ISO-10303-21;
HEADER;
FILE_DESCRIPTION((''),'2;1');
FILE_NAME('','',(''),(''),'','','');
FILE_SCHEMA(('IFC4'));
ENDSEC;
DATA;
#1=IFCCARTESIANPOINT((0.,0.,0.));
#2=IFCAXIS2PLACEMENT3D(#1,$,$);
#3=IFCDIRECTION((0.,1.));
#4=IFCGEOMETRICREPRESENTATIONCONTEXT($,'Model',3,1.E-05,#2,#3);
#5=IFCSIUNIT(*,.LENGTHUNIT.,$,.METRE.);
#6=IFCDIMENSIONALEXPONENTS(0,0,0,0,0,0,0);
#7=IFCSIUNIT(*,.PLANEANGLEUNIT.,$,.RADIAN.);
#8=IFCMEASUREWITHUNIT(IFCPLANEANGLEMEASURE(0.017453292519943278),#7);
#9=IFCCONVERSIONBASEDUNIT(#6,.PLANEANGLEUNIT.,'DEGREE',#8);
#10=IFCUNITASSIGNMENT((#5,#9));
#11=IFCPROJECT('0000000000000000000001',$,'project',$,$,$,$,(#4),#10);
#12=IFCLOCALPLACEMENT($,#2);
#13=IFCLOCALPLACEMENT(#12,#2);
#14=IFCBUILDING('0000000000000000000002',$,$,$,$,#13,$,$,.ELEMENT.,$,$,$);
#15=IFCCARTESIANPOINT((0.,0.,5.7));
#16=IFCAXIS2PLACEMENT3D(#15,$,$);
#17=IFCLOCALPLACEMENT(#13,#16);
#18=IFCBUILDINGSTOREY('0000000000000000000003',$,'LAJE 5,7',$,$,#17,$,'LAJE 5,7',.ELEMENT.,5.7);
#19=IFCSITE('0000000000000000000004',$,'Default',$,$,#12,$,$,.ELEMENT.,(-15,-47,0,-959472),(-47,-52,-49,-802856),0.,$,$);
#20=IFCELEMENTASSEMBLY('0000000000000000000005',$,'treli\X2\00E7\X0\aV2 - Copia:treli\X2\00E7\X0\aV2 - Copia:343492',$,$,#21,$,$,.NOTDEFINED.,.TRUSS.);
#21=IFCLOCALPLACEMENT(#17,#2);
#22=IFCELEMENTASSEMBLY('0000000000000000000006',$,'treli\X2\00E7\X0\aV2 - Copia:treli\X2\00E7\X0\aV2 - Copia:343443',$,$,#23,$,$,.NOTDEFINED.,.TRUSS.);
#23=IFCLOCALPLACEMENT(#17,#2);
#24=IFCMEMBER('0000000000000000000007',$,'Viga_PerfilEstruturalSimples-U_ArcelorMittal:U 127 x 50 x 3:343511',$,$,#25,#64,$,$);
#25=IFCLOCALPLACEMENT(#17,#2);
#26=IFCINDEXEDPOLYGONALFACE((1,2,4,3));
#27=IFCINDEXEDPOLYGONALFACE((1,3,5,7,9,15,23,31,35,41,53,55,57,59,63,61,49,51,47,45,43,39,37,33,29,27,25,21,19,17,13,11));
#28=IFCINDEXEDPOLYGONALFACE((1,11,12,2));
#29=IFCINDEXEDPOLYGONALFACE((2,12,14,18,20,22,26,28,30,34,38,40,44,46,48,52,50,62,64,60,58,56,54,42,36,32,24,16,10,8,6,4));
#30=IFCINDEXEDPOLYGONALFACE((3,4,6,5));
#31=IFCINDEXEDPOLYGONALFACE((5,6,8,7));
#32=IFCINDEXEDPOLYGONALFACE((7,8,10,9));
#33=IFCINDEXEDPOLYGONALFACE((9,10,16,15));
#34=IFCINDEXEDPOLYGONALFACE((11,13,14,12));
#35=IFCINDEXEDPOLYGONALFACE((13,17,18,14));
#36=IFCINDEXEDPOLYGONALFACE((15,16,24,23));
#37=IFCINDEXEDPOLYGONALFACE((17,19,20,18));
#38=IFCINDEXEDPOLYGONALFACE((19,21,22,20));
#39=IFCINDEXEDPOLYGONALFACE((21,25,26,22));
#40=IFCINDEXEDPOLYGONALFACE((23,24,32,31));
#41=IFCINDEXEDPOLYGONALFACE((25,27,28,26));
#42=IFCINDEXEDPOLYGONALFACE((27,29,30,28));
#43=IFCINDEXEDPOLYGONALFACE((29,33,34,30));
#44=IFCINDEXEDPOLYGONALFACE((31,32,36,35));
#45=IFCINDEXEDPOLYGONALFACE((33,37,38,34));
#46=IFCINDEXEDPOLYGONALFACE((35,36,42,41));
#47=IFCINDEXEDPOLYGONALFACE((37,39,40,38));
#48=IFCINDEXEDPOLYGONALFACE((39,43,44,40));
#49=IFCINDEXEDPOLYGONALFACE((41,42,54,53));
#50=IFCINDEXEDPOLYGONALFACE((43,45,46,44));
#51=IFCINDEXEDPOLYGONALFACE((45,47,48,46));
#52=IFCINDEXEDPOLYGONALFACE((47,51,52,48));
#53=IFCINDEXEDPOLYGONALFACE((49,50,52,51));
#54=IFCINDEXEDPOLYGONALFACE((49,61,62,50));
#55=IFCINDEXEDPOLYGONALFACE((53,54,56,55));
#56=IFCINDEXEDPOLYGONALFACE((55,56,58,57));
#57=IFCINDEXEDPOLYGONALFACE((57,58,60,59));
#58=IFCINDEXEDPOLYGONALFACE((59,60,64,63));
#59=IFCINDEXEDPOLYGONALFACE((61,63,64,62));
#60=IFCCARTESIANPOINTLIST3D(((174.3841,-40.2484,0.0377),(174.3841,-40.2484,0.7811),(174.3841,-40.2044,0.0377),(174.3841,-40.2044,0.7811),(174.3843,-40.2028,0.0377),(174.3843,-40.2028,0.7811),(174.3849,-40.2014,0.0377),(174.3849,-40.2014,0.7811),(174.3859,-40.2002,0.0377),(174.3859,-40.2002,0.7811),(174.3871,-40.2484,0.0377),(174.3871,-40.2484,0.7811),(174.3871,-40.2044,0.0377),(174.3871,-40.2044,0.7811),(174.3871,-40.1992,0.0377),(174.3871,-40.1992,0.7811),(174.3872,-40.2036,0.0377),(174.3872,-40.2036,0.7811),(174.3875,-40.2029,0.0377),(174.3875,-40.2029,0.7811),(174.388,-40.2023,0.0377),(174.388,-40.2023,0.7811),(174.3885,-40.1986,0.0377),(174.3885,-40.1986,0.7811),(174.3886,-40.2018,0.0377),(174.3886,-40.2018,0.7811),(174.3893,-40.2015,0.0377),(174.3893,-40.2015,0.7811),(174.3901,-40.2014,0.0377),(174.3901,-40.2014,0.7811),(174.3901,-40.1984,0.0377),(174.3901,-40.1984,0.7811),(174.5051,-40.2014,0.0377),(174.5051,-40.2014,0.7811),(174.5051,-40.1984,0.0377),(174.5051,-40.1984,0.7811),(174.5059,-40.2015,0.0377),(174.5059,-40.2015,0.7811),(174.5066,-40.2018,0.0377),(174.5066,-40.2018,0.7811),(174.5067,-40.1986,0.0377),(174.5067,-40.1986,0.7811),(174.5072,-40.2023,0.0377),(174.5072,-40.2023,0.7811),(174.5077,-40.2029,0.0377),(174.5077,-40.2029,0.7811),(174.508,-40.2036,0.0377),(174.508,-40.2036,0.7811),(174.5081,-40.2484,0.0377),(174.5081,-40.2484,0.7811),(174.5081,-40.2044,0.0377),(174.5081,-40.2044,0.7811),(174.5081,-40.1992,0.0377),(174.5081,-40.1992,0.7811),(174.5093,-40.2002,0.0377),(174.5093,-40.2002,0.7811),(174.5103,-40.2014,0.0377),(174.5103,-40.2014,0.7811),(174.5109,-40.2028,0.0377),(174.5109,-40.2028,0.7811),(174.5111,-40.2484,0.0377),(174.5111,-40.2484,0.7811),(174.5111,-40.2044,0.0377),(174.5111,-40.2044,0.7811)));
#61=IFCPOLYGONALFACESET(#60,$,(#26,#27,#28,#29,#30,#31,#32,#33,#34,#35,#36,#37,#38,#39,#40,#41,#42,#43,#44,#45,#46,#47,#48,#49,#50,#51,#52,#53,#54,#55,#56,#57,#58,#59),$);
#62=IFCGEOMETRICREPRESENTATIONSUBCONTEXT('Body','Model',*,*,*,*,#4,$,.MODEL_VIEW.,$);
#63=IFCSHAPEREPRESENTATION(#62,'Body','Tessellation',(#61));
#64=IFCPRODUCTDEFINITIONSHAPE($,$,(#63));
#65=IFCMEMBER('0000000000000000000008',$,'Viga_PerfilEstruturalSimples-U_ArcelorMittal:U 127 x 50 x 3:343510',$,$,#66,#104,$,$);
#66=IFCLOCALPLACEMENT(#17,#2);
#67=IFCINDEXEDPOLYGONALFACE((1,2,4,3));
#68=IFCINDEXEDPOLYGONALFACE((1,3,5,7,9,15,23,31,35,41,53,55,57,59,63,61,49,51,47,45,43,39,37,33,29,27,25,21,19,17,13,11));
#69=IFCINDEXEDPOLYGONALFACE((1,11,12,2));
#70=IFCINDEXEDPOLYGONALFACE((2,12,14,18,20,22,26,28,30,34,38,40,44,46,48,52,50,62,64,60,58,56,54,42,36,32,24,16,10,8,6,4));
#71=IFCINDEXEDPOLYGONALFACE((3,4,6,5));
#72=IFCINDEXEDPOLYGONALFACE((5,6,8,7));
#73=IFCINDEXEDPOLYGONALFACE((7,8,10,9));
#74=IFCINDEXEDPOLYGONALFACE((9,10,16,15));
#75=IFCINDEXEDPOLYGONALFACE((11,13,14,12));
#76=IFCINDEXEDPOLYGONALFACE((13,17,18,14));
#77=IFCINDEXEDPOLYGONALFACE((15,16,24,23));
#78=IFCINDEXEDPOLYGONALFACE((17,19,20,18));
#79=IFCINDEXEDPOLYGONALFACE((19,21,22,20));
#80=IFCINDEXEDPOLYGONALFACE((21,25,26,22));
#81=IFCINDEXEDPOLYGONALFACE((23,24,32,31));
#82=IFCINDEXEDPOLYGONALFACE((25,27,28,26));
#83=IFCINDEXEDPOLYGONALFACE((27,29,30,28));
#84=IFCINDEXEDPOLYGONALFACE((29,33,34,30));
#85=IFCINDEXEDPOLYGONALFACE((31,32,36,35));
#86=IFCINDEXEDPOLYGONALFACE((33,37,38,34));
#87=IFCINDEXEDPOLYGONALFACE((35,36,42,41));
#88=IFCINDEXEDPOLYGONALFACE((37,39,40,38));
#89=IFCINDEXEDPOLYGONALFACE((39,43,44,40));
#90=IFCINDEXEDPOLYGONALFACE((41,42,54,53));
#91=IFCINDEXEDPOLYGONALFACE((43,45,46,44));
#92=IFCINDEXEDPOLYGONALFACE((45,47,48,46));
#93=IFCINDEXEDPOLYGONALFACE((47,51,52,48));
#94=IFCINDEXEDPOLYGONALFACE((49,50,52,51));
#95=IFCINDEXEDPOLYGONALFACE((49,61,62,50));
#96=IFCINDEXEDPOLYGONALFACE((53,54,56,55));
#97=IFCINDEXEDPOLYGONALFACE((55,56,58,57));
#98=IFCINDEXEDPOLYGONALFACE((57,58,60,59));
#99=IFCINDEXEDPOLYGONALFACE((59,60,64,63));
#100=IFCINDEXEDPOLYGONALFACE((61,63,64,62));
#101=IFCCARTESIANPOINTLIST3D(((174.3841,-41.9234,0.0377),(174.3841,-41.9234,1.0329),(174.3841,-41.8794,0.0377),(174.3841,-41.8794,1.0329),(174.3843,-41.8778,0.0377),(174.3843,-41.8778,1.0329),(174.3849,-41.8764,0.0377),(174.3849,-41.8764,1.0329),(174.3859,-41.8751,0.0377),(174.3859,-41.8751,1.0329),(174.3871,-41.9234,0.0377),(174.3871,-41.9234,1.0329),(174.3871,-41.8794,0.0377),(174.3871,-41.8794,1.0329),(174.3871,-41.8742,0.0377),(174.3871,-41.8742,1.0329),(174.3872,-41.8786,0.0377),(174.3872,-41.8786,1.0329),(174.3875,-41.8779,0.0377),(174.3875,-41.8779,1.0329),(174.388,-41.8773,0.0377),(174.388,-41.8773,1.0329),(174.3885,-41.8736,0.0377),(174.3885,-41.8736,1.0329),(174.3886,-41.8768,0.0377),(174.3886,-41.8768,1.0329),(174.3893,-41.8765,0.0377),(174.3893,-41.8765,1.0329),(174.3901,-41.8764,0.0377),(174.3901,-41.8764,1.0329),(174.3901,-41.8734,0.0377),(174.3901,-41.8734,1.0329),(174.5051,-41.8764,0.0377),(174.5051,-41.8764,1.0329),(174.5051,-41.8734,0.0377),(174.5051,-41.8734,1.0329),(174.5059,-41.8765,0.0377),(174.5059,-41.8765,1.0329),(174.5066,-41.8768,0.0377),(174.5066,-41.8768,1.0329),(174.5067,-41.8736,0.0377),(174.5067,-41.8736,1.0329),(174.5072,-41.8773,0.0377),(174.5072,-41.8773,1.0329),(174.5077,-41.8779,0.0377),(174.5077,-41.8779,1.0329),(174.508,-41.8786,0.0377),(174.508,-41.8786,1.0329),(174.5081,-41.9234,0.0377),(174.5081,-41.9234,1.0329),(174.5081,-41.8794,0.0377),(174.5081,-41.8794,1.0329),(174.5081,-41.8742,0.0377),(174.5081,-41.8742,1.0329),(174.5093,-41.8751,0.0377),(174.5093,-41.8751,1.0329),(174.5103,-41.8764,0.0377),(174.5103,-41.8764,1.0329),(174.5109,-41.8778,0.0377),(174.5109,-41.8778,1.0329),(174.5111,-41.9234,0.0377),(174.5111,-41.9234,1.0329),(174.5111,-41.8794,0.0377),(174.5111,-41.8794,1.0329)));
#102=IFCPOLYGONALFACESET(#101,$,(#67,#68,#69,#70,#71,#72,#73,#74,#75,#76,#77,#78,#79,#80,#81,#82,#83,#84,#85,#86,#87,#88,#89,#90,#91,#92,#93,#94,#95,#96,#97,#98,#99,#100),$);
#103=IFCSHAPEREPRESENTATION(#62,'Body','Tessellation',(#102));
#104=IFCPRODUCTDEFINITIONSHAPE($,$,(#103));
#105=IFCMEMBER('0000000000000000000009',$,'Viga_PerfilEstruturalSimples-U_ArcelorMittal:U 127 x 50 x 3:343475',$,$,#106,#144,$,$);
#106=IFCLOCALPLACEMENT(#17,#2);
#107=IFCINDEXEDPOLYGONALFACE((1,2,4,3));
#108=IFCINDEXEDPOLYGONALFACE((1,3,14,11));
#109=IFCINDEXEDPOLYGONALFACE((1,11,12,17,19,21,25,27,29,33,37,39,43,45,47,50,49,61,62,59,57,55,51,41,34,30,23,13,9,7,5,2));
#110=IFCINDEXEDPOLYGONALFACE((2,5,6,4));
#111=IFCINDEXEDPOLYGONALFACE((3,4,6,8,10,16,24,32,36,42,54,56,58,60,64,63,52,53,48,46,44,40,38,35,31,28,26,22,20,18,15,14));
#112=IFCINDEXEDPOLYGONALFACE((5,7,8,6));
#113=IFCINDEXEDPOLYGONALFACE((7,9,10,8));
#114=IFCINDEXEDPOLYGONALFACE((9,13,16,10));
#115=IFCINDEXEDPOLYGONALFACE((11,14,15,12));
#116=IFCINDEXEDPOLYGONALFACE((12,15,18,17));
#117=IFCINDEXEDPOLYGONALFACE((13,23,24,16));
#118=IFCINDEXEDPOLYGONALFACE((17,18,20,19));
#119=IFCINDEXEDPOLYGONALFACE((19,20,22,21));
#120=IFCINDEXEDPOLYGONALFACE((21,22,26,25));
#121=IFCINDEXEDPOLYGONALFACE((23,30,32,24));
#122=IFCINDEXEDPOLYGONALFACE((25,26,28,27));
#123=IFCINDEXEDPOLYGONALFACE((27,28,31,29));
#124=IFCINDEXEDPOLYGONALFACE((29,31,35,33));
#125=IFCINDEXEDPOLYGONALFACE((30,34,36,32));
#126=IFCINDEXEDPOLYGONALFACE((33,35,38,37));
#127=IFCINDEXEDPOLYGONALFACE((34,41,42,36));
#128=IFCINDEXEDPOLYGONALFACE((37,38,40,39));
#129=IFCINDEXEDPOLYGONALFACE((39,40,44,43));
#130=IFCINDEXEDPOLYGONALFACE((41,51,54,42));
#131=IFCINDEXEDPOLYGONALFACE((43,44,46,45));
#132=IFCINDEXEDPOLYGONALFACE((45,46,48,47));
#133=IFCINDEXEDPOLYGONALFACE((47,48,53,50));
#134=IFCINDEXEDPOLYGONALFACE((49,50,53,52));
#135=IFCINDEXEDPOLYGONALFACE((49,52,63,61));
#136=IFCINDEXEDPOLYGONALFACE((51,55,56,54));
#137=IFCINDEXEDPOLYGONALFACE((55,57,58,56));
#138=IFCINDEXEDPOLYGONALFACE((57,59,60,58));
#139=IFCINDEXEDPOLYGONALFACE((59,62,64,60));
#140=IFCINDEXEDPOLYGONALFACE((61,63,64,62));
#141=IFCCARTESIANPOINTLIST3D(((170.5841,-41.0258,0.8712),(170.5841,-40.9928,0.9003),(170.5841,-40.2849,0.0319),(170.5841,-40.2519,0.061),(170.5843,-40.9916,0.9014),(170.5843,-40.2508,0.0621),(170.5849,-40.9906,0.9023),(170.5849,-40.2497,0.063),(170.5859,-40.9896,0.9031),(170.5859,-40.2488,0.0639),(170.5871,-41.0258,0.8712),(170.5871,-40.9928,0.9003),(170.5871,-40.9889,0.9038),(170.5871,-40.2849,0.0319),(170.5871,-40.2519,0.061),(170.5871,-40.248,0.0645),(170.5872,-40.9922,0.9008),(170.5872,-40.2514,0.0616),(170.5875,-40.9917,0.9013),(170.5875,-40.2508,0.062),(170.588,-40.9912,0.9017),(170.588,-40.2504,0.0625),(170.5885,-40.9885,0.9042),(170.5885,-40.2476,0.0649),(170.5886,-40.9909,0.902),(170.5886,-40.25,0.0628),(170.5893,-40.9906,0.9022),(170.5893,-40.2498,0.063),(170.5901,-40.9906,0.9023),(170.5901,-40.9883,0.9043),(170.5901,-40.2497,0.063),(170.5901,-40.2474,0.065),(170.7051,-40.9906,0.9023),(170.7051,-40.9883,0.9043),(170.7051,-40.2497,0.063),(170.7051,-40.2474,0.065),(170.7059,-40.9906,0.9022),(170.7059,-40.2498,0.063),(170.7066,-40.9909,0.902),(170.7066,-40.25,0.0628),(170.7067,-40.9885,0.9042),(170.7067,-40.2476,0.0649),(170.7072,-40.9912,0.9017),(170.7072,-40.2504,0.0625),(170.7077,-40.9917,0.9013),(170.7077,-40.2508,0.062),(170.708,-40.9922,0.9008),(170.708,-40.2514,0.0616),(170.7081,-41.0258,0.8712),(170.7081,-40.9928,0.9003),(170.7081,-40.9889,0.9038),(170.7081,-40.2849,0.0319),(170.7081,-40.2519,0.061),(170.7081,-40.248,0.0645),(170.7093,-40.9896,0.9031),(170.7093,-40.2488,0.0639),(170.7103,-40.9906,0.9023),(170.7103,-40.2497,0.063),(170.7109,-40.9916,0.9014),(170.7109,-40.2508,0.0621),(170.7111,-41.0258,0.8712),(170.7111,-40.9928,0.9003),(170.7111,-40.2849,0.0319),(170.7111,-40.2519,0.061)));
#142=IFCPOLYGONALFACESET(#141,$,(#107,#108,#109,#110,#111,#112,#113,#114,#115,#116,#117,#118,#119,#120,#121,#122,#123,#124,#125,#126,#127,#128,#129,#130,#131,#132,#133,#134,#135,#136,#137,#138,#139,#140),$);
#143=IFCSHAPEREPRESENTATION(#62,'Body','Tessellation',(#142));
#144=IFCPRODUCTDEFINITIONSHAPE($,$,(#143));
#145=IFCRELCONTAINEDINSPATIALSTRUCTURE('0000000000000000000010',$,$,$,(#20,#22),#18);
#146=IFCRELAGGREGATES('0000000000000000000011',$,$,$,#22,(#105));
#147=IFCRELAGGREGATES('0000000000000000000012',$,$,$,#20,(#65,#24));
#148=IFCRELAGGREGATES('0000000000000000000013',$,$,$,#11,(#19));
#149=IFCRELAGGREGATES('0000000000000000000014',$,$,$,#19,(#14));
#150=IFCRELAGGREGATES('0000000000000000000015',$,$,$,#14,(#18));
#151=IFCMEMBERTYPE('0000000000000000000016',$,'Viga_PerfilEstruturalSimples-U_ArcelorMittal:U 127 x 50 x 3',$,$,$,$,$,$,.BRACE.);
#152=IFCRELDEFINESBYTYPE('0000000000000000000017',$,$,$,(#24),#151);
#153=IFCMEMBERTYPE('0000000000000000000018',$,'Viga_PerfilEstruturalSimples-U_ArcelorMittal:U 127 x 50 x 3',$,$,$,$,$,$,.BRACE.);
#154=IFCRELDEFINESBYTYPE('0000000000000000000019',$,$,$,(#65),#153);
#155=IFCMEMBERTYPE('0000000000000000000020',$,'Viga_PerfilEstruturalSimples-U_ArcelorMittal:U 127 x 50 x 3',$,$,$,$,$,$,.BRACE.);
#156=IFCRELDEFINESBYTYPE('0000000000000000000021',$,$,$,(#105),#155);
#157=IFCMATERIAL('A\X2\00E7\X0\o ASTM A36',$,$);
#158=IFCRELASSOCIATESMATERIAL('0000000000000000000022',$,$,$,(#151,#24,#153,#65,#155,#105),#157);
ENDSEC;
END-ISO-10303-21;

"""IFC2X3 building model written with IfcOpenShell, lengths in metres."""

from ifc_helpers import new_model, entity, si_unit, converted_unit, direction, frame, frame_2d, origin, place, context, subcontext, project, spatial, polyline, circle_curve, parameter, trimmed, segment, composite_curve, outline, extrude, source, transform, mapped, material, type_object, type_shapes, element, aggregate, save


model = new_model("IFC2X3")

# Units and contexts
model_context = context("Model", 3, precision=1e-05, world=origin(), true_north=direction((0.0, 1.0)))
body_context = subcontext(model_context, "Body", "Model", "MODEL_VIEW")
ifc_project = project(units=[si_unit("LENGTHUNIT", "METRE"), converted_unit("PLANEANGLEUNIT", "DEGREE", entity("IfcPlaneAngleMeasure", 0.017453292519943278), si_unit("PLANEANGLEUNIT", "RADIAN"), dimensions=[0, 0, 0, 0, 0, 0, 0])], contexts=[model_context])

# Site, building, storey
site_placement = place(None, origin())
site = spatial("IfcSite", under=ifc_project, at=site_placement, Name="Default", CompositionType="ELEMENT", RefLatitude=(-15, -47, 0, -959472), RefLongitude=(-47, -52, -49, -802856), RefElevation=0.0)
building_placement = place(site_placement, origin())
building = spatial("IfcBuilding", under=site, at=building_placement, CompositionType="ELEMENT")
storey_placement = place(building_placement, frame((0.0, 0.0, 5.7)))
storey = spatial("IfcBuildingStorey", under=building, at=storey_placement, Name="LAJE 5,7", LongName="LAJE 5,7", CompositionType="ELEMENT", Elevation=5.7)

# Element assembly
assembly_1_placement = place(storey_placement, origin())
assembly_1 = element("IfcElementAssembly", 1, at=assembly_1_placement, inside=storey, Name="treliçaV2 - Copia:treliçaV2 - Copia:343492", AssemblyPlace="NOTDEFINED", PredefinedType="TRUSS")
ifc_material = material(Name="Aço ASTM A36")

# Element assembly
assembly_2_placement = place(storey_placement, origin())
assembly_2 = element("IfcElementAssembly", 2, at=assembly_2_placement, inside=storey, Name="treliçaV2 - Copia:treliçaV2 - Copia:343443", AssemblyPlace="NOTDEFINED", PredefinedType="TRUSS")

# Members
member_type_1 = type_object("IfcMemberType", Name="Viga_PerfilEstruturalSimples-U_ArcelorMittal:U 127 x 50 x 3", PredefinedType="BRACE", material=ifc_material)
shared_shape_1 = source(origin(), body_context, "Body", "SweptSolid", [
    extrude(outline(composite_curve([segment(polyline([(-0.0575, -0.0192), (0.0575, -0.0192)]), True, "CONTINUOUS"), segment(trimmed(circle_curve(frame_2d((0.0575, -0.0132), x_axis=(0.0, 1.0)), 0.006), [parameter(180.0)], [parameter(270.0)], True, "PARAMETER"), True, "CONTINUOUS"), segment(polyline([(0.0635, -0.0132), (0.0635, 0.0308)]), True, "CONTINUOUS"), segment(polyline([(0.0635, 0.0308), (0.0605, 0.0308)]), True, "CONTINUOUS"), segment(polyline([(0.0605, 0.0308), (0.0605, -0.0132)]), True, "CONTINUOUS"), segment(trimmed(circle_curve(frame_2d((0.0575, -0.0132), x_axis=(0.0, 1.0)), 0.003), [parameter(180.0)], [parameter(270.0)], True, "PARAMETER"), False, "CONTINUOUS"), segment(polyline([(0.0575, -0.0162), (-0.0575, -0.0162)]), True, "CONTINUOUS"), segment(trimmed(circle_curve(frame_2d((-0.0575, -0.0132), x_axis=(0.0, 1.0)), 0.003), [parameter(90.0)], [parameter(180.0)], True, "PARAMETER"), False, "CONTINUOUS"), segment(polyline([(-0.0605, -0.0132), (-0.0605, 0.0308)]), True, "CONTINUOUS"), segment(polyline([(-0.0605, 0.0308), (-0.0635, 0.0308)]), True, "CONTINUOUS"), segment(polyline([(-0.0635, 0.0308), (-0.0635, -0.0132)]), True, "CONTINUOUS"), segment(trimmed(circle_curve(frame_2d((-0.0575, -0.0132), x_axis=(0.0, 1.0)), 0.006), [parameter(90.0)], [parameter(180.0)], True, "PARAMETER"), True, "CONTINUOUS")], self_intersect=False)), frame((-0.3737, -0.0058, 0.0), z_axis=(1.0, 0.0, 0.0), x_axis=(0.0, 0.0, -1.0)), (0.0, 0.0, 1.0), 0.7434),
])
type_shapes(member_type_1, [shared_shape_1])
member_1_placement = place(assembly_1_placement, frame((174.4476, -40.2234, 0.4114), z_axis=(1.0, 0.0, 0.0), x_axis=(0.0, 0.0, 1.0)))
member_1 = element("IfcMember", 3, at=member_1_placement, type_object=member_type_1, material=ifc_material, Name="Viga_PerfilEstruturalSimples-U_ArcelorMittal:U 127 x 50 x 3:343511", context=body_context, shape_type="MappedRepresentation", body=[
    mapped(shared_shape_1, transform((0.0, 0.0, 0.0), scale=1.0)),
])
member_type_2 = type_object("IfcMemberType", Name="Viga_PerfilEstruturalSimples-U_ArcelorMittal:U 127 x 50 x 3", PredefinedType="BRACE", material=ifc_material)
shared_shape_2 = source(origin(), body_context, "Body", "SweptSolid", [
    extrude(outline(composite_curve([segment(polyline([(-0.0575, -0.0192), (0.0575, -0.0192)]), True, "CONTINUOUS"), segment(trimmed(circle_curve(frame_2d((0.0575, -0.0132), x_axis=(0.0, 1.0)), 0.006), [parameter(180.0)], [parameter(270.0)], True, "PARAMETER"), True, "CONTINUOUS"), segment(polyline([(0.0635, -0.0132), (0.0635, 0.0308)]), True, "CONTINUOUS"), segment(polyline([(0.0635, 0.0308), (0.0605, 0.0308)]), True, "CONTINUOUS"), segment(polyline([(0.0605, 0.0308), (0.0605, -0.0132)]), True, "CONTINUOUS"), segment(trimmed(circle_curve(frame_2d((0.0575, -0.0132), x_axis=(0.0, 1.0)), 0.003), [parameter(180.0)], [parameter(270.0)], True, "PARAMETER"), False, "CONTINUOUS"), segment(polyline([(0.0575, -0.0162), (-0.0575, -0.0162)]), True, "CONTINUOUS"), segment(trimmed(circle_curve(frame_2d((-0.0575, -0.0132), x_axis=(0.0, 1.0)), 0.003), [parameter(90.0)], [parameter(180.0)], True, "PARAMETER"), False, "CONTINUOUS"), segment(polyline([(-0.0605, -0.0132), (-0.0605, 0.0308)]), True, "CONTINUOUS"), segment(polyline([(-0.0605, 0.0308), (-0.0635, 0.0308)]), True, "CONTINUOUS"), segment(polyline([(-0.0635, 0.0308), (-0.0635, -0.0132)]), True, "CONTINUOUS"), segment(trimmed(circle_curve(frame_2d((-0.0575, -0.0132), x_axis=(0.0, 1.0)), 0.006), [parameter(90.0)], [parameter(180.0)], True, "PARAMETER"), True, "CONTINUOUS")], self_intersect=False)), frame((-0.4996, -0.0058, 0.0), z_axis=(1.0, 0.0, 0.0), x_axis=(0.0, 0.0, -1.0)), (0.0, 0.0, 1.0), 0.9952),
])
type_shapes(member_type_2, [shared_shape_2])
member_2_placement = place(assembly_1_placement, frame((174.4476, -41.8984, 0.5373), z_axis=(1.0, 0.0, 0.0), x_axis=(0.0, 0.0, 1.0)))
member_2 = element("IfcMember", 4, at=member_2_placement, type_object=member_type_2, material=ifc_material, Name="Viga_PerfilEstruturalSimples-U_ArcelorMittal:U 127 x 50 x 3:343510", context=body_context, shape_type="MappedRepresentation", body=[
    mapped(shared_shape_2, transform((0.0, 0.0, 0.0), scale=1.0)),
])
member_type_3 = type_object("IfcMemberType", Name="Viga_PerfilEstruturalSimples-U_ArcelorMittal:U 127 x 50 x 3", PredefinedType="BRACE", material=ifc_material)
shared_shape_3 = source(origin(), body_context, "Body", "SweptSolid", [
    extrude(outline(composite_curve([segment(polyline([(-0.0575, -0.0192), (0.0575, -0.0192)]), True, "CONTINUOUS"), segment(trimmed(circle_curve(frame_2d((0.0575, -0.0132), x_axis=(0.0, 1.0)), 0.006), [parameter(180.0)], [parameter(270.0)], True, "PARAMETER"), True, "CONTINUOUS"), segment(polyline([(0.0635, -0.0132), (0.0635, 0.0308)]), True, "CONTINUOUS"), segment(polyline([(0.0635, 0.0308), (0.0605, 0.0308)]), True, "CONTINUOUS"), segment(polyline([(0.0605, 0.0308), (0.0605, -0.0132)]), True, "CONTINUOUS"), segment(trimmed(circle_curve(frame_2d((0.0575, -0.0132), x_axis=(0.0, 1.0)), 0.003), [parameter(180.0)], [parameter(270.0)], True, "PARAMETER"), False, "CONTINUOUS"), segment(polyline([(0.0575, -0.0162), (-0.0575, -0.0162)]), True, "CONTINUOUS"), segment(trimmed(circle_curve(frame_2d((-0.0575, -0.0132), x_axis=(0.0, 1.0)), 0.003), [parameter(90.0)], [parameter(180.0)], True, "PARAMETER"), False, "CONTINUOUS"), segment(polyline([(-0.0605, -0.0132), (-0.0605, 0.0308)]), True, "CONTINUOUS"), segment(polyline([(-0.0605, 0.0308), (-0.0635, 0.0308)]), True, "CONTINUOUS"), segment(polyline([(-0.0635, 0.0308), (-0.0635, -0.0132)]), True, "CONTINUOUS"), segment(trimmed(circle_curve(frame_2d((-0.0575, -0.0132), x_axis=(0.0, 1.0)), 0.006), [parameter(90.0)], [parameter(180.0)], True, "PARAMETER"), True, "CONTINUOUS")], self_intersect=False)), frame((-0.5514, -0.0058, 0.0), z_axis=(1.0, 0.0, 0.0), x_axis=(0.0, 0.0, -1.0)), (0.0, 0.0, 1.0), 1.1195),
])
type_shapes(member_type_3, [shared_shape_3])
member_3_placement = place(assembly_2_placement, frame((170.6476, -40.6421, 0.4744), z_axis=(-1.0, 0.0, 0.0), x_axis=(0.0, 0.661783, -0.749695)))
member_3 = element("IfcMember", 5, at=member_3_placement, type_object=member_type_3, material=ifc_material, Name="Viga_PerfilEstruturalSimples-U_ArcelorMittal:U 127 x 50 x 3:343475", context=body_context, shape_type="MappedRepresentation", body=[
    mapped(shared_shape_3, transform((0.0, 0.0, 0.0), scale=1.0)),
])
aggregate(assembly_2, [member_3])
aggregate(assembly_1, [member_2, member_1])

save(model, "model.ifc")
